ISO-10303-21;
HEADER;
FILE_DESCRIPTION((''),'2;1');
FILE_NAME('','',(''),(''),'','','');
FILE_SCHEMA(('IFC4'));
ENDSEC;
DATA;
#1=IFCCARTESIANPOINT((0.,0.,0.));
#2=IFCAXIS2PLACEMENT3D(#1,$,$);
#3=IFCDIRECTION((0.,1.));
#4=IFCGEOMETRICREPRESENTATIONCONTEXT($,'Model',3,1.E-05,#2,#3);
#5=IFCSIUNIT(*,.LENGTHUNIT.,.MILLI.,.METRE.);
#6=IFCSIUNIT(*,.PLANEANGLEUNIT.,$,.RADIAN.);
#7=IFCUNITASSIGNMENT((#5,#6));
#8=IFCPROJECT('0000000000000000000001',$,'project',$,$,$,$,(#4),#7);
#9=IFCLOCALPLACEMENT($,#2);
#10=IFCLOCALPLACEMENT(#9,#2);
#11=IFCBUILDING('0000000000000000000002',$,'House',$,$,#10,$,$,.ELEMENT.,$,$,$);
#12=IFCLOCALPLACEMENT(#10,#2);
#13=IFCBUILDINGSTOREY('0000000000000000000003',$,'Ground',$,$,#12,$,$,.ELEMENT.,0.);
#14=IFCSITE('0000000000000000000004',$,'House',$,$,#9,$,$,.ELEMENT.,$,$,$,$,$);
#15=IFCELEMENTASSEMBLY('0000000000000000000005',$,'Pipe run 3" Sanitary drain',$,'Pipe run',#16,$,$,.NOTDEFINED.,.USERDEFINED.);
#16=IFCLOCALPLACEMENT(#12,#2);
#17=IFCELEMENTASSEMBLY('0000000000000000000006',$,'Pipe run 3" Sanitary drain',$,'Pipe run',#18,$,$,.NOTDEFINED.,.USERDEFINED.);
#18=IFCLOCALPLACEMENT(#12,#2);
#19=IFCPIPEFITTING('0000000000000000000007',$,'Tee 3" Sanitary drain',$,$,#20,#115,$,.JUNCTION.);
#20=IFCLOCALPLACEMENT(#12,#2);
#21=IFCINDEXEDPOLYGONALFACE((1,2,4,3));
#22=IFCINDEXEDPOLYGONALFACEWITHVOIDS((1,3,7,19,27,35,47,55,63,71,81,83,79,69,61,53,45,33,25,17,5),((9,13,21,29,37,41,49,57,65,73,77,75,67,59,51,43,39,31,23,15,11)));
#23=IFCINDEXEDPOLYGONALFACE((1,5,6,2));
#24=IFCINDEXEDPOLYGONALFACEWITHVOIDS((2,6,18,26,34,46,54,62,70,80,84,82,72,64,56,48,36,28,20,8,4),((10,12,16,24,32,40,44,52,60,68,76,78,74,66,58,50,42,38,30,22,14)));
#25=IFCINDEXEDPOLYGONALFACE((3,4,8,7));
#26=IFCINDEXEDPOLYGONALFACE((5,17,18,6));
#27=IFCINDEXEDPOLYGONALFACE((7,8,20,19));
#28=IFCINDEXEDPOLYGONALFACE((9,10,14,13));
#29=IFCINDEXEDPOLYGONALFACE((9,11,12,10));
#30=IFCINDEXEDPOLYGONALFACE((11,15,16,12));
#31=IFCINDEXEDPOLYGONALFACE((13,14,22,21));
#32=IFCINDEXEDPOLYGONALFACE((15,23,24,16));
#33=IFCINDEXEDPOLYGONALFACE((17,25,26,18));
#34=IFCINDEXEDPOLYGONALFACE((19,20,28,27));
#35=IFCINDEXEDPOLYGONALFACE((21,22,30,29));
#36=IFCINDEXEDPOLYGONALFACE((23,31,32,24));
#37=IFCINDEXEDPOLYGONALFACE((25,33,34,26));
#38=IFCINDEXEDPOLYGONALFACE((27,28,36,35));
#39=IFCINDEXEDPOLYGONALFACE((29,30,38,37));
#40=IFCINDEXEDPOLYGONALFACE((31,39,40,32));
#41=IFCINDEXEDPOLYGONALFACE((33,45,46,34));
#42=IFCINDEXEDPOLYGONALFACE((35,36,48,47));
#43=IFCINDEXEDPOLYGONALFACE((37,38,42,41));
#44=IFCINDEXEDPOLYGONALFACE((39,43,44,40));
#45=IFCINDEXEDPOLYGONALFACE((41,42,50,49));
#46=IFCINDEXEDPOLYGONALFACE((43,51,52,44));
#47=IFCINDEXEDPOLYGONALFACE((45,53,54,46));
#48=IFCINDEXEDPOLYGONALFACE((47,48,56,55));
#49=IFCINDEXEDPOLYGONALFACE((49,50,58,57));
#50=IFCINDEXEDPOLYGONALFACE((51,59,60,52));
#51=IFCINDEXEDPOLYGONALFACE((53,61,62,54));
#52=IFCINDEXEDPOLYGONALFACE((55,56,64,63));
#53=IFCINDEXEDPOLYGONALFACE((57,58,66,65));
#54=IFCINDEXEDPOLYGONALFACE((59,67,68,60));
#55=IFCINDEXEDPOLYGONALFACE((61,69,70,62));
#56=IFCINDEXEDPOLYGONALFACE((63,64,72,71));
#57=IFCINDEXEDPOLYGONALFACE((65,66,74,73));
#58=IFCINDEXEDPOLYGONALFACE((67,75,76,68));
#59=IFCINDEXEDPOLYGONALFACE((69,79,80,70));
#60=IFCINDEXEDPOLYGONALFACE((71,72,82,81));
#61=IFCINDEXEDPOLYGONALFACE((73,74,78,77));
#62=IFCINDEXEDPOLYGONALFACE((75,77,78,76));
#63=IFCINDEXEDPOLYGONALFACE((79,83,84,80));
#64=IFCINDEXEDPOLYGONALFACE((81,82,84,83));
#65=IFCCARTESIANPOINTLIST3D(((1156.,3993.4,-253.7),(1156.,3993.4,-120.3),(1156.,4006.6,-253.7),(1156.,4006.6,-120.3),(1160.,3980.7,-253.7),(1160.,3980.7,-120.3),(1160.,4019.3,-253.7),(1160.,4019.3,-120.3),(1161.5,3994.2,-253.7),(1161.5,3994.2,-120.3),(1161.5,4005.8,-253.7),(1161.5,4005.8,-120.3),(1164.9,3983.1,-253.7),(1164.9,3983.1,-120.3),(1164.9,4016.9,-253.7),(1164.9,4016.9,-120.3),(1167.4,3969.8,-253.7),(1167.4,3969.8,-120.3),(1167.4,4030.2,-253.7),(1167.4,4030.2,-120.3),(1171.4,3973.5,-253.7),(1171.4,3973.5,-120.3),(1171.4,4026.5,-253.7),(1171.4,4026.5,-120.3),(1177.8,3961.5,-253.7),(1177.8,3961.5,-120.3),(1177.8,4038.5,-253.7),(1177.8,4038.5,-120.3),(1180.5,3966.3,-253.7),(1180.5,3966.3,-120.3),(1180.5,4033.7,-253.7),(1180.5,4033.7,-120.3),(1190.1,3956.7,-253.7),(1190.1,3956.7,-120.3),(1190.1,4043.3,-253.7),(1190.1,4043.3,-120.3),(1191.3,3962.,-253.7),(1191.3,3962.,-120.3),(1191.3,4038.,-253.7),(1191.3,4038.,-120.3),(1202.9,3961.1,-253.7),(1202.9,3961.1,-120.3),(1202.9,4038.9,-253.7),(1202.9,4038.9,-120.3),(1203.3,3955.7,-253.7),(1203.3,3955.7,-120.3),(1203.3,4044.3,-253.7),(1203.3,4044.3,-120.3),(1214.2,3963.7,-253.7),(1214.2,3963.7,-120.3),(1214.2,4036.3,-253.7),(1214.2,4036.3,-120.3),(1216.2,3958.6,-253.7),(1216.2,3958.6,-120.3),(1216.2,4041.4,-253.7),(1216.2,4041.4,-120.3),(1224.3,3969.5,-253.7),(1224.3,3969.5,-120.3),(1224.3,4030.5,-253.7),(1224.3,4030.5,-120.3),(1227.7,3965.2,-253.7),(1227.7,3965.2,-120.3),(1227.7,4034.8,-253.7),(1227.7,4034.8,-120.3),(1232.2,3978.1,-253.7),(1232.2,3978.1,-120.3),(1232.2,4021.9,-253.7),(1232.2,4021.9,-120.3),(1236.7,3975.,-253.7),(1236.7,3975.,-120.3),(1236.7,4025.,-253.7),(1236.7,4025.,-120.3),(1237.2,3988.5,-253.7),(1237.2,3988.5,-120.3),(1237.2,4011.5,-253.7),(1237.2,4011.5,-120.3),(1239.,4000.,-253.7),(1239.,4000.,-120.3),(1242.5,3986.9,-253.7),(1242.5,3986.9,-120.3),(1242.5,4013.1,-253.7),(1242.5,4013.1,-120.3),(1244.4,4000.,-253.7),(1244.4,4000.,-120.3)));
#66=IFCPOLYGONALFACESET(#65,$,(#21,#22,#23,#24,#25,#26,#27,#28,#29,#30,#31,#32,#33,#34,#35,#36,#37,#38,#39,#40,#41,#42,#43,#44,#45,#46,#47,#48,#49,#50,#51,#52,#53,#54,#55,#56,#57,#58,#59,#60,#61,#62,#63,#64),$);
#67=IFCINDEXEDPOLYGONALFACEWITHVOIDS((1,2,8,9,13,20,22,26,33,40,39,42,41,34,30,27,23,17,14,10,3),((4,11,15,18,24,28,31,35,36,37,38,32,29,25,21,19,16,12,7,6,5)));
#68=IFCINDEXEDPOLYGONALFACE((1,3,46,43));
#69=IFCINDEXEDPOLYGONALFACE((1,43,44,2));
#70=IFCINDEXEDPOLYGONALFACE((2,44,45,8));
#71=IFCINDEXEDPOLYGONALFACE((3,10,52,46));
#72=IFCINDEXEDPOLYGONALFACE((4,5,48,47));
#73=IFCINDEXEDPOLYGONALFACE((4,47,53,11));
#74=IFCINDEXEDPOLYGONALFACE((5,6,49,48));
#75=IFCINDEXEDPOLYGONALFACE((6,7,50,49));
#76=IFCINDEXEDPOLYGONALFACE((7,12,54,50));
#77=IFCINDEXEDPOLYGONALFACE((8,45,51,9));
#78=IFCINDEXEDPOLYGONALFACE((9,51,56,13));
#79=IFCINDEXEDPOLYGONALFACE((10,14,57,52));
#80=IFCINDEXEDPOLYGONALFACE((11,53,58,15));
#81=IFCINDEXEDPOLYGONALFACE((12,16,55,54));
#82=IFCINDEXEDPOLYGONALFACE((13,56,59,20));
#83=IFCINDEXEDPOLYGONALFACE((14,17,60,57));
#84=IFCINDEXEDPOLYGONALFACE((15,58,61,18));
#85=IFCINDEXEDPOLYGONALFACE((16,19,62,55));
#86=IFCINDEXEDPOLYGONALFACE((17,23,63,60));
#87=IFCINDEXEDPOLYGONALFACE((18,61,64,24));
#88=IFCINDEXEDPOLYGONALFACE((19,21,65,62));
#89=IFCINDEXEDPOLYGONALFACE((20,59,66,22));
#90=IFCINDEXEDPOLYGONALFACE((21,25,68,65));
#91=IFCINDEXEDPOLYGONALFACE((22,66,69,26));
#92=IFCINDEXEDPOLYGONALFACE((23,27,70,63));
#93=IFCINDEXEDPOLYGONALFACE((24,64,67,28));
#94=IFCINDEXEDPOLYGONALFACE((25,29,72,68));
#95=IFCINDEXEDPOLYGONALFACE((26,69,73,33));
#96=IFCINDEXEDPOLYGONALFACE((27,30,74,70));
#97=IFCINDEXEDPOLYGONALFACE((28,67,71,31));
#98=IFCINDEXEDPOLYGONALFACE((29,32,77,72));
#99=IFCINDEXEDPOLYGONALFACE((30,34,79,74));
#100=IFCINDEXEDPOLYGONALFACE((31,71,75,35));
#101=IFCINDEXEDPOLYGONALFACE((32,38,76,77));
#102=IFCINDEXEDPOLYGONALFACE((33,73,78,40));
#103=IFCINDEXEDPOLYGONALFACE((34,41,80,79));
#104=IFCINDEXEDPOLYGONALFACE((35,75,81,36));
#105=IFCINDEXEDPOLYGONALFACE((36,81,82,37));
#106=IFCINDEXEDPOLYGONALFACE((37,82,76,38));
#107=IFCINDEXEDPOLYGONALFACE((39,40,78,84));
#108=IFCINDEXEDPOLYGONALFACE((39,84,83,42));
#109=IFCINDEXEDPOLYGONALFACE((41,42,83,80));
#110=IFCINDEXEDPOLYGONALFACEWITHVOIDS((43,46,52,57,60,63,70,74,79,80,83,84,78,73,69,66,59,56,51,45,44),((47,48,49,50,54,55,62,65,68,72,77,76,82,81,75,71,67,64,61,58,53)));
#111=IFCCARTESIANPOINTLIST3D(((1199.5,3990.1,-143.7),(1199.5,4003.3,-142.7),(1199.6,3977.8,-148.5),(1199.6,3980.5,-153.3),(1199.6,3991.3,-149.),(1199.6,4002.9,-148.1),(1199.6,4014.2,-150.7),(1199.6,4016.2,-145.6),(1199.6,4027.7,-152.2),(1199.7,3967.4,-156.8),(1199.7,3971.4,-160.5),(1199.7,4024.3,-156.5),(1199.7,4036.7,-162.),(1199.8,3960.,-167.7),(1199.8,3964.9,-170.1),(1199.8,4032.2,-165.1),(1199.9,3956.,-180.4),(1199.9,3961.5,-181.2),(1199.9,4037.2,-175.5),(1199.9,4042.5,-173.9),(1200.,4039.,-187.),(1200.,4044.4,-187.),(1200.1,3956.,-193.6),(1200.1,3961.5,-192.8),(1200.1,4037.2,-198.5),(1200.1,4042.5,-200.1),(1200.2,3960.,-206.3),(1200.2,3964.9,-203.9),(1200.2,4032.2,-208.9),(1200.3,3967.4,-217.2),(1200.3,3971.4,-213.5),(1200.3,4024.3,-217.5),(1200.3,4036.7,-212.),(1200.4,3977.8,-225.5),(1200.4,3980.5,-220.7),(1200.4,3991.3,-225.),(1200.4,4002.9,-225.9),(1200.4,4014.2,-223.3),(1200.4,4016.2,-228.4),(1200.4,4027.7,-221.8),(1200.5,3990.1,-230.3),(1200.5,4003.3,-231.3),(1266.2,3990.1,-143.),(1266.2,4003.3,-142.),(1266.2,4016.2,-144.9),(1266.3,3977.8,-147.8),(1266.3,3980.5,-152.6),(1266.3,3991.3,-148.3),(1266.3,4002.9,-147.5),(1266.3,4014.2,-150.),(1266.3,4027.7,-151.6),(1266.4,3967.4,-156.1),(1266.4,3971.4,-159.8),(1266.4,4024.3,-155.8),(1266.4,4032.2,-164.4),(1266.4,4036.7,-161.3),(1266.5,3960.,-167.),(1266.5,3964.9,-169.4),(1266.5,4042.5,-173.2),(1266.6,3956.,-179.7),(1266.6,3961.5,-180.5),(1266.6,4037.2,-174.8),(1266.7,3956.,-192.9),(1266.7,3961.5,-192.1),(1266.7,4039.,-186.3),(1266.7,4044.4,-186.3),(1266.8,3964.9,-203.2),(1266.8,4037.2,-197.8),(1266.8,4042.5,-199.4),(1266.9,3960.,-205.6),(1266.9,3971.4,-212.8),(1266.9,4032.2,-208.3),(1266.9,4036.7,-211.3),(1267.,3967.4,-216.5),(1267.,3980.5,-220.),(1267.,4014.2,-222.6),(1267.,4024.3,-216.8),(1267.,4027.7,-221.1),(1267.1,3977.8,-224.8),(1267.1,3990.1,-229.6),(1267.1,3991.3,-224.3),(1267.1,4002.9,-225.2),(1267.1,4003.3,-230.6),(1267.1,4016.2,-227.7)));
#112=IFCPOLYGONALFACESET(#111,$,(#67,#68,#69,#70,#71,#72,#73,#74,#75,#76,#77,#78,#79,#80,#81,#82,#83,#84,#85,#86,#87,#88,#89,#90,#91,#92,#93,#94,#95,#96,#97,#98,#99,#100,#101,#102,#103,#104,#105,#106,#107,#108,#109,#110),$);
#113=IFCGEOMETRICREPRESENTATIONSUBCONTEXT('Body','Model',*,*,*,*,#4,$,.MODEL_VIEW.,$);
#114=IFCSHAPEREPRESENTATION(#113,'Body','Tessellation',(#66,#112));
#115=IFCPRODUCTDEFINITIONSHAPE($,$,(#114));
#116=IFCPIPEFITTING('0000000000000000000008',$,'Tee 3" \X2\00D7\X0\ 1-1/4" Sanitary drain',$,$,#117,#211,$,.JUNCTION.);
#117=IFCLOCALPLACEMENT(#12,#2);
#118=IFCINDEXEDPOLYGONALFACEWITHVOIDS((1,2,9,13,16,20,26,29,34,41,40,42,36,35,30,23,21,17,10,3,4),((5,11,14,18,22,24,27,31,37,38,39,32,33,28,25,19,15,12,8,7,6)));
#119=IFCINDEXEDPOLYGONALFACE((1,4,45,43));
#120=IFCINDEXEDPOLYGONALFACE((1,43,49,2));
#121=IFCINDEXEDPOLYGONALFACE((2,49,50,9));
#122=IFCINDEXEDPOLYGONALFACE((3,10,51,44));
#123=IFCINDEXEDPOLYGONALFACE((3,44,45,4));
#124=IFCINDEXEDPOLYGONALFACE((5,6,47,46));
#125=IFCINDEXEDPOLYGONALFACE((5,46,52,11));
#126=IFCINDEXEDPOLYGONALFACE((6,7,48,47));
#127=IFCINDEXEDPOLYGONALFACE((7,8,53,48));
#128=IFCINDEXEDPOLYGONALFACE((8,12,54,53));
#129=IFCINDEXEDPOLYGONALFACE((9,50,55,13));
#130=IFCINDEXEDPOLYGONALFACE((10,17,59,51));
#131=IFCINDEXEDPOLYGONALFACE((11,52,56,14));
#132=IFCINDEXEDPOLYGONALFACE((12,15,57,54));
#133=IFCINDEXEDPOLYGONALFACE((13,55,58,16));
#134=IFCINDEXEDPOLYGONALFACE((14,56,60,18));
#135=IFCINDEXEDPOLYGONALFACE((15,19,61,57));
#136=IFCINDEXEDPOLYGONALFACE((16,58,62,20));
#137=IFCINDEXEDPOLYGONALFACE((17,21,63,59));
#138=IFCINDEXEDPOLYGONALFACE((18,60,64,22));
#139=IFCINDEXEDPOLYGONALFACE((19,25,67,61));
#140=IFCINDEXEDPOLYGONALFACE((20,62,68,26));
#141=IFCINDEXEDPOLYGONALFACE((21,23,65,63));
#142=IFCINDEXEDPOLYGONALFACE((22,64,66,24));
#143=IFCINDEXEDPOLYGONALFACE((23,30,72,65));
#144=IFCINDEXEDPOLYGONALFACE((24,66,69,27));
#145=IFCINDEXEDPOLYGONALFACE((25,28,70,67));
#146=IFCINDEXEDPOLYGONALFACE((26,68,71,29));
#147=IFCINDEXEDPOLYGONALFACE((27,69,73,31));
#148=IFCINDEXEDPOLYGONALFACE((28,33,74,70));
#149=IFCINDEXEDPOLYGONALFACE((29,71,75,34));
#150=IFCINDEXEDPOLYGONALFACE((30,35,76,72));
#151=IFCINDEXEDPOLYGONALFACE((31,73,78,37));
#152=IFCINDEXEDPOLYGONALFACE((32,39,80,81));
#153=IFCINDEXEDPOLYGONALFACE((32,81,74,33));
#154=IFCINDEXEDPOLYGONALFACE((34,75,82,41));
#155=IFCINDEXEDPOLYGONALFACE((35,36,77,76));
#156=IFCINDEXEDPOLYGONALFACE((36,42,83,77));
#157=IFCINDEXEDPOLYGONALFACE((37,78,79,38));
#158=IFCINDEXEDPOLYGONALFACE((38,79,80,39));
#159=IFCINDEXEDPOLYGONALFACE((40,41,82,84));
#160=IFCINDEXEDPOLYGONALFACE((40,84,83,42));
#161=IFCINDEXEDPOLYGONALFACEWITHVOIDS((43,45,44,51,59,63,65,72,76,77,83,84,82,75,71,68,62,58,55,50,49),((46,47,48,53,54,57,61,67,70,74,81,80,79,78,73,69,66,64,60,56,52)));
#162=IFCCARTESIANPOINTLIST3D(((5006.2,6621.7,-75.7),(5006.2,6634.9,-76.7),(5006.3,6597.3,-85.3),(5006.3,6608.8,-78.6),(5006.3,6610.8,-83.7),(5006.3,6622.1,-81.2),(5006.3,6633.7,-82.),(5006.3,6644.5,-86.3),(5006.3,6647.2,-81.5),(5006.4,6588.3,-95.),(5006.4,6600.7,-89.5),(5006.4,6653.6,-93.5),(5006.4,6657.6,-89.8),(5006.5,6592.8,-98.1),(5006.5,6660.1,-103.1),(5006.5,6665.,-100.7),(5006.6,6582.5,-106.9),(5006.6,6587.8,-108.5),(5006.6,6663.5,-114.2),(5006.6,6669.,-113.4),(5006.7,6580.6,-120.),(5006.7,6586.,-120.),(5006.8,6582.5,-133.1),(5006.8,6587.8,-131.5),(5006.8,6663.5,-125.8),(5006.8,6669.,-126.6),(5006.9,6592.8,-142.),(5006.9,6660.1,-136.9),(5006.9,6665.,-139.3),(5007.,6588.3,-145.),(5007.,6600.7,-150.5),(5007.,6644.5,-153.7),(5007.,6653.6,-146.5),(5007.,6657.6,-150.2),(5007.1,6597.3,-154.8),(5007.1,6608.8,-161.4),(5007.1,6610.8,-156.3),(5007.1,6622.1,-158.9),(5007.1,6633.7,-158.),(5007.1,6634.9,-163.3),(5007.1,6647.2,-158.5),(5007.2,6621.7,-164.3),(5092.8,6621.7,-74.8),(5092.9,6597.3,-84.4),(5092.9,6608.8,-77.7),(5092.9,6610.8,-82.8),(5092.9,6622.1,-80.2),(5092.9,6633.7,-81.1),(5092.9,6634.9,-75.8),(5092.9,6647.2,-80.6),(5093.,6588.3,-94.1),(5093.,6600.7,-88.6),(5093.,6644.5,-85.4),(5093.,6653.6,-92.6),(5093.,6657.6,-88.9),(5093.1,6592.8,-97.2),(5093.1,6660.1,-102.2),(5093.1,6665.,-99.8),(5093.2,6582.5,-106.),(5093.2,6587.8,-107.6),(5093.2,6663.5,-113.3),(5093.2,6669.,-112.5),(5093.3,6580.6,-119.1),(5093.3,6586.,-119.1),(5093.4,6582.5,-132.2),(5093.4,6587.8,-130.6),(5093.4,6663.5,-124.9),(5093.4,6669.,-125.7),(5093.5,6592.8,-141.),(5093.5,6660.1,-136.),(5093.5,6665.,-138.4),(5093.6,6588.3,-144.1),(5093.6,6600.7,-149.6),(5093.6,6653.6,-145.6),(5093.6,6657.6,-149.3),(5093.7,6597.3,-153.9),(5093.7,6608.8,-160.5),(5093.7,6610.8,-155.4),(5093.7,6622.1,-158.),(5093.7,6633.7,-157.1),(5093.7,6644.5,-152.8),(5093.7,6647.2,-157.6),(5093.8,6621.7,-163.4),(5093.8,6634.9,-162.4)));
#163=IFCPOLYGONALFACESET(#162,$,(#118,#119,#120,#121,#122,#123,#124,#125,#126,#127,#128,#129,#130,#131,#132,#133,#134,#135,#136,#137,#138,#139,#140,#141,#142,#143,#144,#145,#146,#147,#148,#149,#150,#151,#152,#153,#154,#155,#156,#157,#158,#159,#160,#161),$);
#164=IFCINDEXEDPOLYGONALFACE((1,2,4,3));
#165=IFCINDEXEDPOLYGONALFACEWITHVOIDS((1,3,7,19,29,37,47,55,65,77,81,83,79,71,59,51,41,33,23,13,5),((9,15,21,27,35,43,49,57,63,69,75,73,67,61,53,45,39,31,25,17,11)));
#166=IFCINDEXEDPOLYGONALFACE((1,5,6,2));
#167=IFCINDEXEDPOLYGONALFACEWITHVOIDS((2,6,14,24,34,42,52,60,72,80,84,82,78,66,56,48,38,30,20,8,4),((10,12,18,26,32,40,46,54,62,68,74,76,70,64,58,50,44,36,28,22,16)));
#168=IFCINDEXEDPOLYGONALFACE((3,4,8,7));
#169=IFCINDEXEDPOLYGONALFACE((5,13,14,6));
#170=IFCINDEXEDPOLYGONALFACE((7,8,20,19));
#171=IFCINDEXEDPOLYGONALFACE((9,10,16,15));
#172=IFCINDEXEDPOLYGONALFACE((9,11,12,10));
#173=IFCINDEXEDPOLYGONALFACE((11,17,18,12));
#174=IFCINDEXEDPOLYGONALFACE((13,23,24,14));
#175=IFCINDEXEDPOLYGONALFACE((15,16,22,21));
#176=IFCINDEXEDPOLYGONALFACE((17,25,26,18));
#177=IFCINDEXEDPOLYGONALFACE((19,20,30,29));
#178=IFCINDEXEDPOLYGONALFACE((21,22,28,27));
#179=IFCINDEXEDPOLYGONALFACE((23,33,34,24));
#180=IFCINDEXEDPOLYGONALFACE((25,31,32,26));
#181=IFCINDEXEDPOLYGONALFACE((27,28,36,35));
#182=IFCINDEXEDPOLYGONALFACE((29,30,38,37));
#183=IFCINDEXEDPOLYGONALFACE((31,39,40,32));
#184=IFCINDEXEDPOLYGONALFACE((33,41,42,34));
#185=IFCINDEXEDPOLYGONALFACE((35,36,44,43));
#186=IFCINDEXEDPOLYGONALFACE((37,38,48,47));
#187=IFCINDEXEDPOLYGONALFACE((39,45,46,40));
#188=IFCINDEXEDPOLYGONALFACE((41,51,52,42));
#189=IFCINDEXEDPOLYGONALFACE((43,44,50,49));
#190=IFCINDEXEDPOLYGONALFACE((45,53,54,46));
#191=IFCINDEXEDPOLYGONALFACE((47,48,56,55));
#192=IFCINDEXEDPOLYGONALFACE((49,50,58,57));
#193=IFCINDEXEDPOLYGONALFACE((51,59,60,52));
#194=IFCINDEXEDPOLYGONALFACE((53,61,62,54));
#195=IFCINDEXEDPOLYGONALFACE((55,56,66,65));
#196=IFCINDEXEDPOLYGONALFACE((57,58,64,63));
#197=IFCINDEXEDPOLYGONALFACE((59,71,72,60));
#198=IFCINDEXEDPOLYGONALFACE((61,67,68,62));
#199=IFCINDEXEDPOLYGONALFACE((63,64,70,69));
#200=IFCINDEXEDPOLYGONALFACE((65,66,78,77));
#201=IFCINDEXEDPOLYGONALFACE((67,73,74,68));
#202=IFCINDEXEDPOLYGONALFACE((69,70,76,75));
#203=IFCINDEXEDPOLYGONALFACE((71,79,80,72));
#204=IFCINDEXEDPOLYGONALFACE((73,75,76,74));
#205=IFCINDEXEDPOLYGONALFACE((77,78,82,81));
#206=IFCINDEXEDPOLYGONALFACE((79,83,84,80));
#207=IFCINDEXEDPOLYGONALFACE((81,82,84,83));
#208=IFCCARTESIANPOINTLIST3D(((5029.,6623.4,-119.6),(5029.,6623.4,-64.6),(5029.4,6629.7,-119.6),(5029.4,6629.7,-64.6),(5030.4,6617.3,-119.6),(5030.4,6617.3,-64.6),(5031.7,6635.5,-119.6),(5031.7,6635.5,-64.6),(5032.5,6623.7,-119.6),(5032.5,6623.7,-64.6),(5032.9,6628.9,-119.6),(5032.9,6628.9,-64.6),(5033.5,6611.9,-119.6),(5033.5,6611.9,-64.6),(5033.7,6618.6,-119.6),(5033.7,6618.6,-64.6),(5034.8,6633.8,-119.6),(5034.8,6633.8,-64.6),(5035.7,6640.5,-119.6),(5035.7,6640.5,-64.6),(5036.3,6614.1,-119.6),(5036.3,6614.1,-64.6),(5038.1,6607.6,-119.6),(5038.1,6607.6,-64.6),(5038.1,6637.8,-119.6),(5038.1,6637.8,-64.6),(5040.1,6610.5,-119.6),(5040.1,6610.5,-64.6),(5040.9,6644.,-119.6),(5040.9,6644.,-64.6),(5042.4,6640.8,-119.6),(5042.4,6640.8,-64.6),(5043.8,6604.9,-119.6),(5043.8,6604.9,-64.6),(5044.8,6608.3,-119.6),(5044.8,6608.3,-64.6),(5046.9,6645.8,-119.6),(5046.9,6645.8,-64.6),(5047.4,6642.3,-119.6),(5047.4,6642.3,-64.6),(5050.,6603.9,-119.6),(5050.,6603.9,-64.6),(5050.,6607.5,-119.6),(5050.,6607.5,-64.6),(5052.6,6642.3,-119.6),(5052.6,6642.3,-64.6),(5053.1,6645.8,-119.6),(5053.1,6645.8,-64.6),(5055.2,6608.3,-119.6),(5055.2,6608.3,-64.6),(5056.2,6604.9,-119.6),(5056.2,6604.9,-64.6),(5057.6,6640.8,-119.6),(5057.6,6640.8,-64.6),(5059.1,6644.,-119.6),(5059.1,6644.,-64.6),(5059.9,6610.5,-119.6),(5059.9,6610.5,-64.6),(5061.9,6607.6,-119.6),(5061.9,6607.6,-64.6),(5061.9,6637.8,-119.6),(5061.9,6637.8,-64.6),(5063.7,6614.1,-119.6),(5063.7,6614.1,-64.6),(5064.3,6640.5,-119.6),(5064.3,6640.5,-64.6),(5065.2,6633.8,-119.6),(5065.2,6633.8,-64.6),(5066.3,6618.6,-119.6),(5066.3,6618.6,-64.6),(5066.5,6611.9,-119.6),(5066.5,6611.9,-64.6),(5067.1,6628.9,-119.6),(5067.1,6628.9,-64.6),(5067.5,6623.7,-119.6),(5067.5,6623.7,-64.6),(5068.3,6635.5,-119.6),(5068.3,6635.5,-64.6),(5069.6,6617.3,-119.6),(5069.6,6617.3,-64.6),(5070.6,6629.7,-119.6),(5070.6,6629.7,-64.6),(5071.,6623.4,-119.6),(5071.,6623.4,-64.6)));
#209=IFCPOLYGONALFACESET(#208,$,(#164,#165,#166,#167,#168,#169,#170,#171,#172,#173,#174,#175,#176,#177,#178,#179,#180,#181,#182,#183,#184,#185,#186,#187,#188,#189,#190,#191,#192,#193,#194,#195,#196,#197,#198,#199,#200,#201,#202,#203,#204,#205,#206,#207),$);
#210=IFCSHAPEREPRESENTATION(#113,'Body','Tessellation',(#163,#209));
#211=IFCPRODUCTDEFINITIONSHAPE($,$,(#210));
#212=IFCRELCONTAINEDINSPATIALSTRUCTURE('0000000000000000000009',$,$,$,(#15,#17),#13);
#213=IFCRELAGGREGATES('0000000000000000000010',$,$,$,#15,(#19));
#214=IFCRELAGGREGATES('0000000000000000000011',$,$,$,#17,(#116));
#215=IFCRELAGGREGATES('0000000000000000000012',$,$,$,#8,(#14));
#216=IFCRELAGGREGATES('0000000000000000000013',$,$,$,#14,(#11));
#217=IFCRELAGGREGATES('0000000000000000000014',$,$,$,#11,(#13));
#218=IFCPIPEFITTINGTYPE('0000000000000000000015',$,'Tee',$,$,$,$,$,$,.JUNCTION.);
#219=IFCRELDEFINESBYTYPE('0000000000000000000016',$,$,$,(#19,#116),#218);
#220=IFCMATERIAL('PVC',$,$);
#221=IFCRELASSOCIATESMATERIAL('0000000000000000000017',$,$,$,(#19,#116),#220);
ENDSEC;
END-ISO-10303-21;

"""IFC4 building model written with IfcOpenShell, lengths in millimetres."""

from ifc_helpers import new_model, si_unit, direction, frame, origin, origin_with_axes, origin_2d, place, context, subcontext, project, spatial, hollow_circle, extrude, material, type_object, element, aggregate, save


model = new_model("IFC4")

# Units and contexts
model_context = context("Model", 3, precision=1e-05, world=origin(), true_north=direction((0.0, 1.0)))
body_context = subcontext(model_context, "Body", "Model", "MODEL_VIEW")
ifc_project = project(units=[si_unit("LENGTHUNIT", "METRE", prefix="MILLI"), si_unit("PLANEANGLEUNIT", "RADIAN")], contexts=[model_context])

# Site, building, storey
site_placement = place(None, origin())
site = spatial("IfcSite", under=ifc_project, at=site_placement, Name="House", CompositionType="ELEMENT")
building_placement = place(site_placement, origin())
building = spatial("IfcBuilding", under=site, at=building_placement, Name="House", CompositionType="ELEMENT")
storey_placement = place(building_placement, origin())
storey = spatial("IfcBuildingStorey", under=building, at=storey_placement, Name="Ground", CompositionType="ELEMENT", Elevation=0.0)

# Element assemblies
ifc_material = material(Name="PVC")
assembly_1_placement = place(storey_placement, origin_with_axes())
assembly_1 = element("IfcElementAssembly", 1, at=assembly_1_placement, inside=storey, Name="Pipe run 3\" Sanitary drain", ObjectType="Pipe run", AssemblyPlace="NOTDEFINED", PredefinedType="USERDEFINED")
assembly_2_placement = place(storey_placement, origin_with_axes())
assembly_2 = element("IfcElementAssembly", 2, at=assembly_2_placement, inside=storey, Name="Pipe run 3\" Sanitary drain", ObjectType="Pipe run", AssemblyPlace="NOTDEFINED", PredefinedType="USERDEFINED")

# Pipe fittings
pipe_fitting_type_1 = type_object("IfcPipeFittingType", Name="Tee", PredefinedType="JUNCTION")
pipe_fitting_1_placement = place(storey_placement, origin_with_axes())
pipe_fitting_1 = element("IfcPipeFitting", 3, at=pipe_fitting_1_placement, type_object=pipe_fitting_type_1, material=ifc_material, Name="Tee 3\" Sanitary drain", PredefinedType="JUNCTION", context=body_context, shape_type="SweptSolid", body=[
    extrude(hollow_circle(Radius=44.5, WallThickness=5.5, at=origin_2d()), frame((1200.0, 4000.0, -120.3), z_axis=(0.0, 0.0, -1.0), x_axis=(1.0, 0.0, 0.0)), (0.0, 0.0, 1.0), 133.3),
    extrude(hollow_circle(Radius=44.5, WallThickness=5.5, at=origin_2d()), frame((1200.0, 4000.0, -187.0), z_axis=(0.999946, 0.0, 0.010416), x_axis=(0.0, 1.0, 0.0)), (0.0, 0.0, 1.0), 66.7),
])
aggregate(assembly_1, [pipe_fitting_1])
pipe_fitting_2_placement = place(storey_placement, origin_with_axes())
pipe_fitting_2 = element("IfcPipeFitting", 4, at=pipe_fitting_2_placement, type_object=pipe_fitting_type_1, material=ifc_material, Name="Tee 3\" × 1-1/4\" Sanitary drain", PredefinedType="JUNCTION", context=body_context, shape_type="SweptSolid", body=[
    extrude(hollow_circle(Radius=44.5, WallThickness=5.5, at=origin_2d()), frame((5093.3, 6625.0, -119.1), z_axis=(-0.999946, 0.0, -0.010416), x_axis=(0.0, -1.0, 0.0)), (0.0, 0.0, 1.0), 86.6),
    extrude(hollow_circle(Radius=21.1, WallThickness=3.6, at=origin_2d()), frame((5050.0, 6625.0, -119.6), z_axis=(0.0, 0.0, 1.0), x_axis=(0.0, -1.0, 0.0)), (0.0, 0.0, 1.0), 55.0),
])
aggregate(assembly_2, [pipe_fitting_2])

save(model, "model.ifc")
